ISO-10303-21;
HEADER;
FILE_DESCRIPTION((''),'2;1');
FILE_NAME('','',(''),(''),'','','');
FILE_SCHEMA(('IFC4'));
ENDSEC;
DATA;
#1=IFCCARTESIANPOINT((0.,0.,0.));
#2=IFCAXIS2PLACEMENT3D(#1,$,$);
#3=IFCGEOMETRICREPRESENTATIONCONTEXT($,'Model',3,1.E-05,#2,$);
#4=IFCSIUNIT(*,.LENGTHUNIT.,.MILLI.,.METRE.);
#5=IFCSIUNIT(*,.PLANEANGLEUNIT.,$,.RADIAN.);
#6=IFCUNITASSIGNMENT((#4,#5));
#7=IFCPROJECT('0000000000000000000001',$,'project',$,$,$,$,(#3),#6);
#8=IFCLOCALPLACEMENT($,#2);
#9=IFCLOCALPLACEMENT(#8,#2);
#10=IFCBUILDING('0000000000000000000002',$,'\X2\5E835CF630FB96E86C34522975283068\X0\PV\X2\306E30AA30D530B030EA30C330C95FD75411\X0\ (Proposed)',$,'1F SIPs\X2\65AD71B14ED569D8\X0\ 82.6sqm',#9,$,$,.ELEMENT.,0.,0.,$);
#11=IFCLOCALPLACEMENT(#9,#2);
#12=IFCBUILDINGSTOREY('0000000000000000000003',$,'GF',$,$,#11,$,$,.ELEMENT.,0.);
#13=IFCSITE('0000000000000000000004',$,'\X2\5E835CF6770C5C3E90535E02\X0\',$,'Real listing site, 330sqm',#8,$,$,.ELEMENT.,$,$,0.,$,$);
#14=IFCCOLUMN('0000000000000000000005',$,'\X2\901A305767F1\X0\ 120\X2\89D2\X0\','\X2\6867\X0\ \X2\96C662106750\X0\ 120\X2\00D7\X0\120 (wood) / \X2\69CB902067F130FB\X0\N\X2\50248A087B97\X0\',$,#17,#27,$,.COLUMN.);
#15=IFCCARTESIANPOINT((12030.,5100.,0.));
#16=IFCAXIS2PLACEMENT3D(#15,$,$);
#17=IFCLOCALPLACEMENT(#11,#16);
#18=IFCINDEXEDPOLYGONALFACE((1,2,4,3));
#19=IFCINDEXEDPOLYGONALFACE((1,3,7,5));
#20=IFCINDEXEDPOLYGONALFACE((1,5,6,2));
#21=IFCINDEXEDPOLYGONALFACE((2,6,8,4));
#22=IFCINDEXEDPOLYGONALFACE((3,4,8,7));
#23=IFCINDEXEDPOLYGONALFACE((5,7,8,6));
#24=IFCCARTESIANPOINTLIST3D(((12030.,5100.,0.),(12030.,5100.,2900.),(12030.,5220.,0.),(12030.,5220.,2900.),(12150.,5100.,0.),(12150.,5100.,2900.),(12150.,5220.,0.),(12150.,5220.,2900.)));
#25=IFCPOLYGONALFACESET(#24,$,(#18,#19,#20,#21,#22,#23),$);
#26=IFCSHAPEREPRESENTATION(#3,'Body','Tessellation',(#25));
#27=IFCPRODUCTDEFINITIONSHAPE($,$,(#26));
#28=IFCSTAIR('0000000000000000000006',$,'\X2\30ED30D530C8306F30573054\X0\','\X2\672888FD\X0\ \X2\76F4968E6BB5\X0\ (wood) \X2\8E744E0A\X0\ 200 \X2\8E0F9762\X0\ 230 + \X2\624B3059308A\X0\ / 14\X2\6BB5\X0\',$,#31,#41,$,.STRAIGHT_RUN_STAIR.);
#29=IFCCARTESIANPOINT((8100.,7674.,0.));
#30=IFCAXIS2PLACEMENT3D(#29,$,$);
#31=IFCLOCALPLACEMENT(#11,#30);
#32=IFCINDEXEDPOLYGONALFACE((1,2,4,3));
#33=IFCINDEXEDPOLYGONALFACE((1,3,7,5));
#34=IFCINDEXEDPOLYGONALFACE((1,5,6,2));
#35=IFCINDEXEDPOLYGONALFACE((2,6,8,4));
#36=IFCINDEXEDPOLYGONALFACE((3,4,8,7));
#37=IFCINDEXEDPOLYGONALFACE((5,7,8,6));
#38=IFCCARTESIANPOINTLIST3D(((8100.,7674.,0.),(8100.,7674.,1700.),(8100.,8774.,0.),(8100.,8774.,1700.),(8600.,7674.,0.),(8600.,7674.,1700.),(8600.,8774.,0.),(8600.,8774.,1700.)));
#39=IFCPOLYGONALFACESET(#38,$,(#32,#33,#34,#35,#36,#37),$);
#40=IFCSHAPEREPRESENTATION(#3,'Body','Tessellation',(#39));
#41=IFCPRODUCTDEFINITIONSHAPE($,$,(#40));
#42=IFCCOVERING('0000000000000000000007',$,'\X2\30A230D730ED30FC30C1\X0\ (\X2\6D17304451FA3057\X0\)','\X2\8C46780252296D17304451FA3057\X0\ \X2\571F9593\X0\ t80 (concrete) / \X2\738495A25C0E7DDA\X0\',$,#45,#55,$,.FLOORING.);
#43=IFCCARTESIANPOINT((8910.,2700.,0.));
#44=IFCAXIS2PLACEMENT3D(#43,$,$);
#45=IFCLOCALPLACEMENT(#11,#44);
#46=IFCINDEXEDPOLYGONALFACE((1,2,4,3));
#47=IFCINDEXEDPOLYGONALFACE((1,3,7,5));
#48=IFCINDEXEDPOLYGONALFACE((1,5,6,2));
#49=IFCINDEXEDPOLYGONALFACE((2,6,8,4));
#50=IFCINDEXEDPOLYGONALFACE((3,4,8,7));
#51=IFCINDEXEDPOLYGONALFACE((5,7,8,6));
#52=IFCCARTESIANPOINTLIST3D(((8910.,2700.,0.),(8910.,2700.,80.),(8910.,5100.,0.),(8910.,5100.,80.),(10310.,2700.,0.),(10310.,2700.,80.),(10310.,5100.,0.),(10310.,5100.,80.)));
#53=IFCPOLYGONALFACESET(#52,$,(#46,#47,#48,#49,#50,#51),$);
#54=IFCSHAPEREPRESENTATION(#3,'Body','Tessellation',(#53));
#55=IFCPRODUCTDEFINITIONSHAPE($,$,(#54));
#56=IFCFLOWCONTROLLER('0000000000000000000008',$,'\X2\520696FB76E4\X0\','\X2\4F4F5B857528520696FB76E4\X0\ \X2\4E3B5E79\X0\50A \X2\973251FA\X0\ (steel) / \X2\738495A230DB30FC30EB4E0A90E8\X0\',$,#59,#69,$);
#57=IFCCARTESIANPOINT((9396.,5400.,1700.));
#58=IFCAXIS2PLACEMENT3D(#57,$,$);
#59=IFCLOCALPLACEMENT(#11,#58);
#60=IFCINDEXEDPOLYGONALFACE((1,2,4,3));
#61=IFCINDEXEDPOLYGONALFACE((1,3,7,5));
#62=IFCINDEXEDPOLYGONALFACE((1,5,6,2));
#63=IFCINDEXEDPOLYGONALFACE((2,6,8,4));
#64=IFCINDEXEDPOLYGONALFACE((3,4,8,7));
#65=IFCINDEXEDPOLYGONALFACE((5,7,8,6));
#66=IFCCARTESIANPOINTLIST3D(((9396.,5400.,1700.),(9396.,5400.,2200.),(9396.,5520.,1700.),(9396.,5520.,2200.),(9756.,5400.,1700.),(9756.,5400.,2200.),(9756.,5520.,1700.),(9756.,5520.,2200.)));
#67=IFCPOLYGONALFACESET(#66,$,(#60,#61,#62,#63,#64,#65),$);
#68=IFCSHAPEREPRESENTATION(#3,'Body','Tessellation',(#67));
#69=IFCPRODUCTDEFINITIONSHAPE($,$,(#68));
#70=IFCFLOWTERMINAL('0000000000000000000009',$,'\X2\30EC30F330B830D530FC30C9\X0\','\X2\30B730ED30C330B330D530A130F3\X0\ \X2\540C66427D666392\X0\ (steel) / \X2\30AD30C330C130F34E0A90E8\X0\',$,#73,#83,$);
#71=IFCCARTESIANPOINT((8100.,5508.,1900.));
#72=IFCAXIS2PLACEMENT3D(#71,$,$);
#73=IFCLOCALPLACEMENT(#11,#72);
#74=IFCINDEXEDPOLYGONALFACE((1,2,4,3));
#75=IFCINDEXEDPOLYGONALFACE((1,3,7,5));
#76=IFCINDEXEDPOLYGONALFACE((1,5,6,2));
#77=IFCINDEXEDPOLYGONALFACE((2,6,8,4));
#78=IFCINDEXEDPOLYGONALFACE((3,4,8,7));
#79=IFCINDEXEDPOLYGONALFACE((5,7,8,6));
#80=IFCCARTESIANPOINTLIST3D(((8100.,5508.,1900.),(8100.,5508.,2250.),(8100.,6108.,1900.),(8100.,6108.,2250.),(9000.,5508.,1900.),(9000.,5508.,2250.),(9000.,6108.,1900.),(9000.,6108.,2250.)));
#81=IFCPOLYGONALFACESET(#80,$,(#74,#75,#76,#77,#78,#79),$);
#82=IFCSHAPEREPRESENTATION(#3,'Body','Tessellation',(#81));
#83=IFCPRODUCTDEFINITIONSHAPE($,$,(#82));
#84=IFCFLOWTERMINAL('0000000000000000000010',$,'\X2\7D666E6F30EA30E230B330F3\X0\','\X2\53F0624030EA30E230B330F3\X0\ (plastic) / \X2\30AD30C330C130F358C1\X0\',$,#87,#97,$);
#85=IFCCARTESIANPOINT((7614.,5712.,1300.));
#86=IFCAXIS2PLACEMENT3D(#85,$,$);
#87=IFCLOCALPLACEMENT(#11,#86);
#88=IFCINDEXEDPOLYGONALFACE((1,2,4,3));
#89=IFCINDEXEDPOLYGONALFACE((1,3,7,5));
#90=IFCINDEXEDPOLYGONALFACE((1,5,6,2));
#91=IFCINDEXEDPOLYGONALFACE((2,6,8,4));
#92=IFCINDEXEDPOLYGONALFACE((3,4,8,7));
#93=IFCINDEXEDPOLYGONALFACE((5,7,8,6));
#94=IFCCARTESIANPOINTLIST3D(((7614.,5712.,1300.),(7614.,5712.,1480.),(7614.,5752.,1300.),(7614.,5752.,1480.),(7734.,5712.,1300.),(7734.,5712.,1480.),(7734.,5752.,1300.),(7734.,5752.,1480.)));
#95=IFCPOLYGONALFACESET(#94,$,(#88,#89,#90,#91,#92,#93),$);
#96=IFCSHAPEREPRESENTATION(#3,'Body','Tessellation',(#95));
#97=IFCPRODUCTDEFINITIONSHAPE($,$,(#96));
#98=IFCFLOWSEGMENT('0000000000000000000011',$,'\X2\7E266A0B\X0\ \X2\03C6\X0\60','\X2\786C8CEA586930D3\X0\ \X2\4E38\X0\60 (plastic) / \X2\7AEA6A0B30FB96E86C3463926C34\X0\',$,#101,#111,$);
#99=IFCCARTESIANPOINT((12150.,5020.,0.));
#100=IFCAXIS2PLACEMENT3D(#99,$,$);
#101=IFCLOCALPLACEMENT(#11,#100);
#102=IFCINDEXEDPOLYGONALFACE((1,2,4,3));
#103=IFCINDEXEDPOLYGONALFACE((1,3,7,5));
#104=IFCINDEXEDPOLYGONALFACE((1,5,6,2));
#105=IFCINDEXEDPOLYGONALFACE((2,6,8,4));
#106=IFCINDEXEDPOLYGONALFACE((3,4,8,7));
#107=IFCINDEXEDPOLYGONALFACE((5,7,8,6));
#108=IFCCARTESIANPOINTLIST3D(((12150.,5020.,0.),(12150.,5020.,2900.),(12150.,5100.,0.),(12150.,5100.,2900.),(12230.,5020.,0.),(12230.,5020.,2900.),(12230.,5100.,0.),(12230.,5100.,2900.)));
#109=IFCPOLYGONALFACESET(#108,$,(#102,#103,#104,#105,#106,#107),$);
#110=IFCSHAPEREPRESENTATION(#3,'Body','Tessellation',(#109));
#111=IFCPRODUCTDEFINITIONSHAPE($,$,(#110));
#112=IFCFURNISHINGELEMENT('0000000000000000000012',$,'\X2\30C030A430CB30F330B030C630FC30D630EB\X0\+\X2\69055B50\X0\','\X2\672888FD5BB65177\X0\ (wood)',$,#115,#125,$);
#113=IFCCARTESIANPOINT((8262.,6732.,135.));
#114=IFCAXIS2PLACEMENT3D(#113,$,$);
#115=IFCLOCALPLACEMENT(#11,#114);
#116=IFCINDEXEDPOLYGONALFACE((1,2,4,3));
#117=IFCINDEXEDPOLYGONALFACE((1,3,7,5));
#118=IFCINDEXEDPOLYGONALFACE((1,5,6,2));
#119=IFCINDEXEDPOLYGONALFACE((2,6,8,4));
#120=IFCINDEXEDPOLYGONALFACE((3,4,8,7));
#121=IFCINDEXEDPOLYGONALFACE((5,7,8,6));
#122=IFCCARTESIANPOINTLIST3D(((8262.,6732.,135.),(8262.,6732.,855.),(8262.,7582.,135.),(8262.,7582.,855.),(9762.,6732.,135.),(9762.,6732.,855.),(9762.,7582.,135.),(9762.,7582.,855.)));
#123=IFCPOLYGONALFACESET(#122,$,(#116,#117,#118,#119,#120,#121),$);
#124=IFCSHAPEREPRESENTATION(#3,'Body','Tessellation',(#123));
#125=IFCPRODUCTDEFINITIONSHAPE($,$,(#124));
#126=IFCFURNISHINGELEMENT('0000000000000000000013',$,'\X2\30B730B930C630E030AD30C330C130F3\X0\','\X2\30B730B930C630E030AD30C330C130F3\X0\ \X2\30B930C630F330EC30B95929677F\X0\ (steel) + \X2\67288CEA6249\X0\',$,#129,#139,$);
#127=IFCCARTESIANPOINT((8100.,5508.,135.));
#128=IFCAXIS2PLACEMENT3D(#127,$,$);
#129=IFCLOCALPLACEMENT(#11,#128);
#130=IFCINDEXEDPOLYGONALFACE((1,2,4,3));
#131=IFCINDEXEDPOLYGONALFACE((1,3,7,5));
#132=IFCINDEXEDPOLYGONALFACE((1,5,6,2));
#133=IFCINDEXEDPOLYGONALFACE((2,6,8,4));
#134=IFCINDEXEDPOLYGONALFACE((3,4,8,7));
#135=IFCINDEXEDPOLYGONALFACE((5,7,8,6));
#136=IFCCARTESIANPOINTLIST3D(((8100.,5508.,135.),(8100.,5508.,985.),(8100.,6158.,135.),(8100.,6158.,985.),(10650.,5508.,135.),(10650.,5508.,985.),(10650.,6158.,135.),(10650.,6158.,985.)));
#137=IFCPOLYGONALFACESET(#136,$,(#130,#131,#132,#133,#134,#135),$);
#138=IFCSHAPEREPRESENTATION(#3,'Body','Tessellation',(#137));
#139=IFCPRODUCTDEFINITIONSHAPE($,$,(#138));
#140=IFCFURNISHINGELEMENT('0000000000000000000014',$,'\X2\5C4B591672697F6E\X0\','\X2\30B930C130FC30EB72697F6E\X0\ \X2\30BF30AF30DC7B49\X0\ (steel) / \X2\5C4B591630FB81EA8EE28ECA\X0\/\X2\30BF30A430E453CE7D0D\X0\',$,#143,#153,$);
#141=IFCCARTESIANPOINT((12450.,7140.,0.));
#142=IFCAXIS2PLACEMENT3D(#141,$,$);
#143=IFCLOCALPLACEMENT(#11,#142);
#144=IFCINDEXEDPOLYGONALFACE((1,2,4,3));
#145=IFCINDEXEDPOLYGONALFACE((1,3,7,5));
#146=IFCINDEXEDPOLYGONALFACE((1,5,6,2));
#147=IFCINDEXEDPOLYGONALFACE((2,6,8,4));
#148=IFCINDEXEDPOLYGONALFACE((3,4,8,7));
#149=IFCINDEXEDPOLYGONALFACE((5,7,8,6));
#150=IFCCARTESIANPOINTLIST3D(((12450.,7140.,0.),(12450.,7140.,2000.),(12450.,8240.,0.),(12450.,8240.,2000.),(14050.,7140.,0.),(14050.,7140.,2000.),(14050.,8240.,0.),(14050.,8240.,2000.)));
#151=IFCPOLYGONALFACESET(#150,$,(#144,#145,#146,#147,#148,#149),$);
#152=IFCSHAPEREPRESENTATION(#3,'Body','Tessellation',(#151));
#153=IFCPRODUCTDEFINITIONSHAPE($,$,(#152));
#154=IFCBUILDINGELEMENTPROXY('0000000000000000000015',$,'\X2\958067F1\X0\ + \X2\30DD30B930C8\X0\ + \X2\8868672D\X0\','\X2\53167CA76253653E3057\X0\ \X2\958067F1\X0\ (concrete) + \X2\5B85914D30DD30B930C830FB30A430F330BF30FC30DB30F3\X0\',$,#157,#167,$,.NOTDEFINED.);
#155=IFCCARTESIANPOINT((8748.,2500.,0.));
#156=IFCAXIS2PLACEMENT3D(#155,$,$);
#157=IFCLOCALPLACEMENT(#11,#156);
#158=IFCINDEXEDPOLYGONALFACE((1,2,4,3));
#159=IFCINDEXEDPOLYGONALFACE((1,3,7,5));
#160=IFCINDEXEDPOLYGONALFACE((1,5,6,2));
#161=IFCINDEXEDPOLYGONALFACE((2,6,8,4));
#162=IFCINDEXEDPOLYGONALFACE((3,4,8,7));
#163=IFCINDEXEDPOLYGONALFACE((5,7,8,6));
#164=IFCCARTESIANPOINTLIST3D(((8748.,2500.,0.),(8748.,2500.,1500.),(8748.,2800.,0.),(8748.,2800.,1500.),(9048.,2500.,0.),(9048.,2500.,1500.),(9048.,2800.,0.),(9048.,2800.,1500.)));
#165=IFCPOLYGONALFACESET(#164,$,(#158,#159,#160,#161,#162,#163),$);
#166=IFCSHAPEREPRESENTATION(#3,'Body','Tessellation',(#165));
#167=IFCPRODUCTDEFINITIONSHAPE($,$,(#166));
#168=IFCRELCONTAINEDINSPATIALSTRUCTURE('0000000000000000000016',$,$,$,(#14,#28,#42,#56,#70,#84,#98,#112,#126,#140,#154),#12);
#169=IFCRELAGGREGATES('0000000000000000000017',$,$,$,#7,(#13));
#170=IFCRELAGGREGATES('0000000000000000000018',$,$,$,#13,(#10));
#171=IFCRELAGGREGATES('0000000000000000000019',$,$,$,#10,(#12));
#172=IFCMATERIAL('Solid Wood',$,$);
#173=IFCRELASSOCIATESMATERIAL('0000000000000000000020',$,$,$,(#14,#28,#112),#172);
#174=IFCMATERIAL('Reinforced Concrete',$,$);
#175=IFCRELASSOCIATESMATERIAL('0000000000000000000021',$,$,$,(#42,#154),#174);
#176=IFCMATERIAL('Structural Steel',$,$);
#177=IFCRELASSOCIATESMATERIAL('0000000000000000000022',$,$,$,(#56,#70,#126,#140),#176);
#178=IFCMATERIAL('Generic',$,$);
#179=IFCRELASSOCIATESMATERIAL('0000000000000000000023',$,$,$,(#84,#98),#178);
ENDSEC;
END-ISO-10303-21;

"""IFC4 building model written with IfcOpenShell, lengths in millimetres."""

from ifc_helpers import new_model, si_unit, frame, frame_2d, origin, place, context, project, spatial, rectangle, extrude, material, element, save


model = new_model("IFC4")

# Units and contexts
model_context = context("Model", 3, precision=1e-05, world=origin())
ifc_project = project(units=[si_unit("LENGTHUNIT", "METRE", prefix="MILLI"), si_unit("PLANEANGLEUNIT", "RADIAN")], contexts=[model_context])

# Site, building, storey
site_placement = place(None, origin())
site = spatial("IfcSite", under=ifc_project, at=site_placement, Name="広島県尾道市", ObjectType="Real listing site, 330sqm", CompositionType="ELEMENT", RefElevation=0.0)
building_placement = place(site_placement, origin())
building = spatial("IfcBuilding", under=site, at=building_placement, Name="広島・雨水利用とPVのオフグリッド志向 (Proposed)", ObjectType="1F SIPs断熱仕様 82.6sqm", CompositionType="ELEMENT", ElevationOfRefHeight=0.0, ElevationOfTerrain=0.0)
storey_placement = place(building_placement, origin())
storey = spatial("IfcBuildingStorey", under=building, at=storey_placement, Name="GF", CompositionType="ELEMENT", Elevation=0.0)

# Column
ifc_material_1 = material(Name="Solid Wood")
column_1_placement = place(storey_placement, frame((12030.0, 5100.0, 0.0)))
element("IfcColumn", 1, at=column_1_placement, inside=storey, material=ifc_material_1, Name="通し柱 120角", Description="桧 集成材 120×120 (wood) / 構造柱・N値計算", PredefinedType="COLUMN", context=model_context, shape_type="SweptSolid", body=[
    extrude(rectangle(XDim=120.0, YDim=120.0, at=frame_2d((60.0, 60.0))), frame((12030.0, 5100.0, 0.0)), (0.0, 0.0, 1.0), 2900.0),
])

# Stair
stair_placement = place(storey_placement, frame((8100.0, 7674.0, 0.0)))
element("IfcStair", 2, at=stair_placement, inside=storey, material=ifc_material_1, Name="ロフトはしご", Description="木製 直階段 (wood) 蹴上 200 踏面 230 + 手すり / 14段", PredefinedType="STRAIGHT_RUN_STAIR", context=model_context, shape_type="SweptSolid", body=[
    extrude(rectangle(XDim=500.0, YDim=1100.0, at=frame_2d((250.0, 550.0))), frame((8100.0, 7674.0, 0.0)), (0.0, 0.0, 1.0), 1700.0),
])

# Covering
ifc_material_2 = material(Name="Reinforced Concrete")
covering_placement = place(storey_placement, frame((8910.0, 2700.0, 0.0)))
element("IfcCovering", 3, at=covering_placement, inside=storey, material=ifc_material_2, Name="アプローチ (洗い出し)", Description="豆砂利洗い出し 土間 t80 (concrete) / 玄関導線", PredefinedType="FLOORING", context=model_context, shape_type="SweptSolid", body=[
    extrude(rectangle(XDim=1400.0, YDim=2400.0, at=frame_2d((700.0, 1200.0))), frame((8910.0, 2700.0, 0.0)), (0.0, 0.0, 1.0), 80.0),
])

# Flow controller
ifc_material_3 = material(Name="Structural Steel")
flow_controller_placement = place(storey_placement, frame((9396.0, 5400.0, 1700.0)))
element("IfcFlowController", 4, at=flow_controller_placement, inside=storey, material=ifc_material_3, Name="分電盤", Description="住宅用分電盤 主幹50A 露出 (steel) / 玄関ホール上部", context=model_context, shape_type="SweptSolid", body=[
    extrude(rectangle(XDim=360.0, YDim=120.0, at=frame_2d((180.0, 60.0))), frame((9396.0, 5400.0, 1700.0)), (0.0, 0.0, 1.0), 500.0),
])

# Flow terminals
flow_terminal_1_placement = place(storey_placement, frame((8100.0, 5508.0, 1900.0)))
element("IfcFlowTerminal", 5, at=flow_terminal_1_placement, inside=storey, material=ifc_material_3, Name="レンジフード", Description="シロッコファン 同時給排 (steel) / キッチン上部", context=model_context, shape_type="SweptSolid", body=[
    extrude(rectangle(XDim=900.0, YDim=600.0, at=frame_2d((450.0, 300.0))), frame((8100.0, 5508.0, 1900.0)), (0.0, 0.0, 1.0), 350.0),
])
ifc_material_4 = material(Name="Generic")
flow_terminal_2_placement = place(storey_placement, frame((7614.0, 5712.0, 1300.0)))
element("IfcFlowTerminal", 6, at=flow_terminal_2_placement, inside=storey, material=ifc_material_4, Name="給湯リモコン", Description="台所リモコン (plastic) / キッチン壁", context=model_context, shape_type="SweptSolid", body=[
    extrude(rectangle(XDim=120.0, YDim=40.0, at=frame_2d((60.0, 20.0))), frame((7614.0, 5712.0, 1300.0)), (0.0, 0.0, 1.0), 180.0),
])

# Flow segment
flow_segment_placement = place(storey_placement, frame((12150.0, 5020.0, 0.0)))
element("IfcFlowSegment", 7, at=flow_segment_placement, inside=storey, material=ifc_material_4, Name="縦樋 φ60", Description="硬質塩ビ 丸60 (plastic) / 竪樋・雨水排水", context=model_context, shape_type="SweptSolid", body=[
    extrude(rectangle(XDim=80.0, YDim=80.0, at=frame_2d((40.0, 40.0))), frame((12150.0, 5020.0, 0.0)), (0.0, 0.0, 1.0), 2900.0),
])

# Furnishing elements
furnishing_1_placement = place(storey_placement, frame((8262.0, 6732.0, 135.0)))
element("IfcFurnishingElement", 8, at=furnishing_1_placement, inside=storey, material=ifc_material_1, Name="ダイニングテーブル+椅子", Description="木製家具 (wood)", context=model_context, shape_type="SweptSolid", body=[
    extrude(rectangle(XDim=1500.0, YDim=850.0, at=frame_2d((750.0, 425.0))), frame((8262.0, 6732.0, 135.0)), (0.0, 0.0, 1.0), 720.0),
])
furnishing_2_placement = place(storey_placement, frame((8100.0, 5508.0, 135.0)))
element("IfcFurnishingElement", 9, at=furnishing_2_placement, inside=storey, material=ifc_material_3, Name="システムキッチン", Description="システムキッチン ステンレス天板 (steel) + 木質扉", context=model_context, shape_type="SweptSolid", body=[
    extrude(rectangle(XDim=2550.0, YDim=650.0, at=frame_2d((1275.0, 325.0))), frame((8100.0, 5508.0, 135.0)), (0.0, 0.0, 1.0), 850.0),
])
furnishing_3_placement = place(storey_placement, frame((12450.0, 7140.0, 0.0)))
element("IfcFurnishingElement", 10, at=furnishing_3_placement, inside=storey, material=ifc_material_3, Name="屋外物置", Description="スチール物置 タクボ等 (steel) / 屋外・自転車/タイヤ収納", context=model_context, shape_type="SweptSolid", body=[
    extrude(rectangle(XDim=1600.0, YDim=1100.0, at=frame_2d((800.0, 550.0))), frame((12450.0, 7140.0, 0.0)), (0.0, 0.0, 1.0), 2000.0),
])

# Building element proxy
proxy_placement = place(storey_placement, frame((8748.0, 2500.0, 0.0)))
element("IfcBuildingElementProxy", 11, at=proxy_placement, inside=storey, material=ifc_material_2, Name="門柱 + ポスト + 表札", Description="化粧打放し 門柱 (concrete) + 宅配ポスト・インターホン", PredefinedType="NOTDEFINED", context=model_context, shape_type="SweptSolid", body=[
    extrude(rectangle(XDim=300.0, YDim=300.0, at=frame_2d((150.0, 150.0))), frame((8748.0, 2500.0, 0.0)), (0.0, 0.0, 1.0), 1500.0),
])

save(model, "model.ifc")
